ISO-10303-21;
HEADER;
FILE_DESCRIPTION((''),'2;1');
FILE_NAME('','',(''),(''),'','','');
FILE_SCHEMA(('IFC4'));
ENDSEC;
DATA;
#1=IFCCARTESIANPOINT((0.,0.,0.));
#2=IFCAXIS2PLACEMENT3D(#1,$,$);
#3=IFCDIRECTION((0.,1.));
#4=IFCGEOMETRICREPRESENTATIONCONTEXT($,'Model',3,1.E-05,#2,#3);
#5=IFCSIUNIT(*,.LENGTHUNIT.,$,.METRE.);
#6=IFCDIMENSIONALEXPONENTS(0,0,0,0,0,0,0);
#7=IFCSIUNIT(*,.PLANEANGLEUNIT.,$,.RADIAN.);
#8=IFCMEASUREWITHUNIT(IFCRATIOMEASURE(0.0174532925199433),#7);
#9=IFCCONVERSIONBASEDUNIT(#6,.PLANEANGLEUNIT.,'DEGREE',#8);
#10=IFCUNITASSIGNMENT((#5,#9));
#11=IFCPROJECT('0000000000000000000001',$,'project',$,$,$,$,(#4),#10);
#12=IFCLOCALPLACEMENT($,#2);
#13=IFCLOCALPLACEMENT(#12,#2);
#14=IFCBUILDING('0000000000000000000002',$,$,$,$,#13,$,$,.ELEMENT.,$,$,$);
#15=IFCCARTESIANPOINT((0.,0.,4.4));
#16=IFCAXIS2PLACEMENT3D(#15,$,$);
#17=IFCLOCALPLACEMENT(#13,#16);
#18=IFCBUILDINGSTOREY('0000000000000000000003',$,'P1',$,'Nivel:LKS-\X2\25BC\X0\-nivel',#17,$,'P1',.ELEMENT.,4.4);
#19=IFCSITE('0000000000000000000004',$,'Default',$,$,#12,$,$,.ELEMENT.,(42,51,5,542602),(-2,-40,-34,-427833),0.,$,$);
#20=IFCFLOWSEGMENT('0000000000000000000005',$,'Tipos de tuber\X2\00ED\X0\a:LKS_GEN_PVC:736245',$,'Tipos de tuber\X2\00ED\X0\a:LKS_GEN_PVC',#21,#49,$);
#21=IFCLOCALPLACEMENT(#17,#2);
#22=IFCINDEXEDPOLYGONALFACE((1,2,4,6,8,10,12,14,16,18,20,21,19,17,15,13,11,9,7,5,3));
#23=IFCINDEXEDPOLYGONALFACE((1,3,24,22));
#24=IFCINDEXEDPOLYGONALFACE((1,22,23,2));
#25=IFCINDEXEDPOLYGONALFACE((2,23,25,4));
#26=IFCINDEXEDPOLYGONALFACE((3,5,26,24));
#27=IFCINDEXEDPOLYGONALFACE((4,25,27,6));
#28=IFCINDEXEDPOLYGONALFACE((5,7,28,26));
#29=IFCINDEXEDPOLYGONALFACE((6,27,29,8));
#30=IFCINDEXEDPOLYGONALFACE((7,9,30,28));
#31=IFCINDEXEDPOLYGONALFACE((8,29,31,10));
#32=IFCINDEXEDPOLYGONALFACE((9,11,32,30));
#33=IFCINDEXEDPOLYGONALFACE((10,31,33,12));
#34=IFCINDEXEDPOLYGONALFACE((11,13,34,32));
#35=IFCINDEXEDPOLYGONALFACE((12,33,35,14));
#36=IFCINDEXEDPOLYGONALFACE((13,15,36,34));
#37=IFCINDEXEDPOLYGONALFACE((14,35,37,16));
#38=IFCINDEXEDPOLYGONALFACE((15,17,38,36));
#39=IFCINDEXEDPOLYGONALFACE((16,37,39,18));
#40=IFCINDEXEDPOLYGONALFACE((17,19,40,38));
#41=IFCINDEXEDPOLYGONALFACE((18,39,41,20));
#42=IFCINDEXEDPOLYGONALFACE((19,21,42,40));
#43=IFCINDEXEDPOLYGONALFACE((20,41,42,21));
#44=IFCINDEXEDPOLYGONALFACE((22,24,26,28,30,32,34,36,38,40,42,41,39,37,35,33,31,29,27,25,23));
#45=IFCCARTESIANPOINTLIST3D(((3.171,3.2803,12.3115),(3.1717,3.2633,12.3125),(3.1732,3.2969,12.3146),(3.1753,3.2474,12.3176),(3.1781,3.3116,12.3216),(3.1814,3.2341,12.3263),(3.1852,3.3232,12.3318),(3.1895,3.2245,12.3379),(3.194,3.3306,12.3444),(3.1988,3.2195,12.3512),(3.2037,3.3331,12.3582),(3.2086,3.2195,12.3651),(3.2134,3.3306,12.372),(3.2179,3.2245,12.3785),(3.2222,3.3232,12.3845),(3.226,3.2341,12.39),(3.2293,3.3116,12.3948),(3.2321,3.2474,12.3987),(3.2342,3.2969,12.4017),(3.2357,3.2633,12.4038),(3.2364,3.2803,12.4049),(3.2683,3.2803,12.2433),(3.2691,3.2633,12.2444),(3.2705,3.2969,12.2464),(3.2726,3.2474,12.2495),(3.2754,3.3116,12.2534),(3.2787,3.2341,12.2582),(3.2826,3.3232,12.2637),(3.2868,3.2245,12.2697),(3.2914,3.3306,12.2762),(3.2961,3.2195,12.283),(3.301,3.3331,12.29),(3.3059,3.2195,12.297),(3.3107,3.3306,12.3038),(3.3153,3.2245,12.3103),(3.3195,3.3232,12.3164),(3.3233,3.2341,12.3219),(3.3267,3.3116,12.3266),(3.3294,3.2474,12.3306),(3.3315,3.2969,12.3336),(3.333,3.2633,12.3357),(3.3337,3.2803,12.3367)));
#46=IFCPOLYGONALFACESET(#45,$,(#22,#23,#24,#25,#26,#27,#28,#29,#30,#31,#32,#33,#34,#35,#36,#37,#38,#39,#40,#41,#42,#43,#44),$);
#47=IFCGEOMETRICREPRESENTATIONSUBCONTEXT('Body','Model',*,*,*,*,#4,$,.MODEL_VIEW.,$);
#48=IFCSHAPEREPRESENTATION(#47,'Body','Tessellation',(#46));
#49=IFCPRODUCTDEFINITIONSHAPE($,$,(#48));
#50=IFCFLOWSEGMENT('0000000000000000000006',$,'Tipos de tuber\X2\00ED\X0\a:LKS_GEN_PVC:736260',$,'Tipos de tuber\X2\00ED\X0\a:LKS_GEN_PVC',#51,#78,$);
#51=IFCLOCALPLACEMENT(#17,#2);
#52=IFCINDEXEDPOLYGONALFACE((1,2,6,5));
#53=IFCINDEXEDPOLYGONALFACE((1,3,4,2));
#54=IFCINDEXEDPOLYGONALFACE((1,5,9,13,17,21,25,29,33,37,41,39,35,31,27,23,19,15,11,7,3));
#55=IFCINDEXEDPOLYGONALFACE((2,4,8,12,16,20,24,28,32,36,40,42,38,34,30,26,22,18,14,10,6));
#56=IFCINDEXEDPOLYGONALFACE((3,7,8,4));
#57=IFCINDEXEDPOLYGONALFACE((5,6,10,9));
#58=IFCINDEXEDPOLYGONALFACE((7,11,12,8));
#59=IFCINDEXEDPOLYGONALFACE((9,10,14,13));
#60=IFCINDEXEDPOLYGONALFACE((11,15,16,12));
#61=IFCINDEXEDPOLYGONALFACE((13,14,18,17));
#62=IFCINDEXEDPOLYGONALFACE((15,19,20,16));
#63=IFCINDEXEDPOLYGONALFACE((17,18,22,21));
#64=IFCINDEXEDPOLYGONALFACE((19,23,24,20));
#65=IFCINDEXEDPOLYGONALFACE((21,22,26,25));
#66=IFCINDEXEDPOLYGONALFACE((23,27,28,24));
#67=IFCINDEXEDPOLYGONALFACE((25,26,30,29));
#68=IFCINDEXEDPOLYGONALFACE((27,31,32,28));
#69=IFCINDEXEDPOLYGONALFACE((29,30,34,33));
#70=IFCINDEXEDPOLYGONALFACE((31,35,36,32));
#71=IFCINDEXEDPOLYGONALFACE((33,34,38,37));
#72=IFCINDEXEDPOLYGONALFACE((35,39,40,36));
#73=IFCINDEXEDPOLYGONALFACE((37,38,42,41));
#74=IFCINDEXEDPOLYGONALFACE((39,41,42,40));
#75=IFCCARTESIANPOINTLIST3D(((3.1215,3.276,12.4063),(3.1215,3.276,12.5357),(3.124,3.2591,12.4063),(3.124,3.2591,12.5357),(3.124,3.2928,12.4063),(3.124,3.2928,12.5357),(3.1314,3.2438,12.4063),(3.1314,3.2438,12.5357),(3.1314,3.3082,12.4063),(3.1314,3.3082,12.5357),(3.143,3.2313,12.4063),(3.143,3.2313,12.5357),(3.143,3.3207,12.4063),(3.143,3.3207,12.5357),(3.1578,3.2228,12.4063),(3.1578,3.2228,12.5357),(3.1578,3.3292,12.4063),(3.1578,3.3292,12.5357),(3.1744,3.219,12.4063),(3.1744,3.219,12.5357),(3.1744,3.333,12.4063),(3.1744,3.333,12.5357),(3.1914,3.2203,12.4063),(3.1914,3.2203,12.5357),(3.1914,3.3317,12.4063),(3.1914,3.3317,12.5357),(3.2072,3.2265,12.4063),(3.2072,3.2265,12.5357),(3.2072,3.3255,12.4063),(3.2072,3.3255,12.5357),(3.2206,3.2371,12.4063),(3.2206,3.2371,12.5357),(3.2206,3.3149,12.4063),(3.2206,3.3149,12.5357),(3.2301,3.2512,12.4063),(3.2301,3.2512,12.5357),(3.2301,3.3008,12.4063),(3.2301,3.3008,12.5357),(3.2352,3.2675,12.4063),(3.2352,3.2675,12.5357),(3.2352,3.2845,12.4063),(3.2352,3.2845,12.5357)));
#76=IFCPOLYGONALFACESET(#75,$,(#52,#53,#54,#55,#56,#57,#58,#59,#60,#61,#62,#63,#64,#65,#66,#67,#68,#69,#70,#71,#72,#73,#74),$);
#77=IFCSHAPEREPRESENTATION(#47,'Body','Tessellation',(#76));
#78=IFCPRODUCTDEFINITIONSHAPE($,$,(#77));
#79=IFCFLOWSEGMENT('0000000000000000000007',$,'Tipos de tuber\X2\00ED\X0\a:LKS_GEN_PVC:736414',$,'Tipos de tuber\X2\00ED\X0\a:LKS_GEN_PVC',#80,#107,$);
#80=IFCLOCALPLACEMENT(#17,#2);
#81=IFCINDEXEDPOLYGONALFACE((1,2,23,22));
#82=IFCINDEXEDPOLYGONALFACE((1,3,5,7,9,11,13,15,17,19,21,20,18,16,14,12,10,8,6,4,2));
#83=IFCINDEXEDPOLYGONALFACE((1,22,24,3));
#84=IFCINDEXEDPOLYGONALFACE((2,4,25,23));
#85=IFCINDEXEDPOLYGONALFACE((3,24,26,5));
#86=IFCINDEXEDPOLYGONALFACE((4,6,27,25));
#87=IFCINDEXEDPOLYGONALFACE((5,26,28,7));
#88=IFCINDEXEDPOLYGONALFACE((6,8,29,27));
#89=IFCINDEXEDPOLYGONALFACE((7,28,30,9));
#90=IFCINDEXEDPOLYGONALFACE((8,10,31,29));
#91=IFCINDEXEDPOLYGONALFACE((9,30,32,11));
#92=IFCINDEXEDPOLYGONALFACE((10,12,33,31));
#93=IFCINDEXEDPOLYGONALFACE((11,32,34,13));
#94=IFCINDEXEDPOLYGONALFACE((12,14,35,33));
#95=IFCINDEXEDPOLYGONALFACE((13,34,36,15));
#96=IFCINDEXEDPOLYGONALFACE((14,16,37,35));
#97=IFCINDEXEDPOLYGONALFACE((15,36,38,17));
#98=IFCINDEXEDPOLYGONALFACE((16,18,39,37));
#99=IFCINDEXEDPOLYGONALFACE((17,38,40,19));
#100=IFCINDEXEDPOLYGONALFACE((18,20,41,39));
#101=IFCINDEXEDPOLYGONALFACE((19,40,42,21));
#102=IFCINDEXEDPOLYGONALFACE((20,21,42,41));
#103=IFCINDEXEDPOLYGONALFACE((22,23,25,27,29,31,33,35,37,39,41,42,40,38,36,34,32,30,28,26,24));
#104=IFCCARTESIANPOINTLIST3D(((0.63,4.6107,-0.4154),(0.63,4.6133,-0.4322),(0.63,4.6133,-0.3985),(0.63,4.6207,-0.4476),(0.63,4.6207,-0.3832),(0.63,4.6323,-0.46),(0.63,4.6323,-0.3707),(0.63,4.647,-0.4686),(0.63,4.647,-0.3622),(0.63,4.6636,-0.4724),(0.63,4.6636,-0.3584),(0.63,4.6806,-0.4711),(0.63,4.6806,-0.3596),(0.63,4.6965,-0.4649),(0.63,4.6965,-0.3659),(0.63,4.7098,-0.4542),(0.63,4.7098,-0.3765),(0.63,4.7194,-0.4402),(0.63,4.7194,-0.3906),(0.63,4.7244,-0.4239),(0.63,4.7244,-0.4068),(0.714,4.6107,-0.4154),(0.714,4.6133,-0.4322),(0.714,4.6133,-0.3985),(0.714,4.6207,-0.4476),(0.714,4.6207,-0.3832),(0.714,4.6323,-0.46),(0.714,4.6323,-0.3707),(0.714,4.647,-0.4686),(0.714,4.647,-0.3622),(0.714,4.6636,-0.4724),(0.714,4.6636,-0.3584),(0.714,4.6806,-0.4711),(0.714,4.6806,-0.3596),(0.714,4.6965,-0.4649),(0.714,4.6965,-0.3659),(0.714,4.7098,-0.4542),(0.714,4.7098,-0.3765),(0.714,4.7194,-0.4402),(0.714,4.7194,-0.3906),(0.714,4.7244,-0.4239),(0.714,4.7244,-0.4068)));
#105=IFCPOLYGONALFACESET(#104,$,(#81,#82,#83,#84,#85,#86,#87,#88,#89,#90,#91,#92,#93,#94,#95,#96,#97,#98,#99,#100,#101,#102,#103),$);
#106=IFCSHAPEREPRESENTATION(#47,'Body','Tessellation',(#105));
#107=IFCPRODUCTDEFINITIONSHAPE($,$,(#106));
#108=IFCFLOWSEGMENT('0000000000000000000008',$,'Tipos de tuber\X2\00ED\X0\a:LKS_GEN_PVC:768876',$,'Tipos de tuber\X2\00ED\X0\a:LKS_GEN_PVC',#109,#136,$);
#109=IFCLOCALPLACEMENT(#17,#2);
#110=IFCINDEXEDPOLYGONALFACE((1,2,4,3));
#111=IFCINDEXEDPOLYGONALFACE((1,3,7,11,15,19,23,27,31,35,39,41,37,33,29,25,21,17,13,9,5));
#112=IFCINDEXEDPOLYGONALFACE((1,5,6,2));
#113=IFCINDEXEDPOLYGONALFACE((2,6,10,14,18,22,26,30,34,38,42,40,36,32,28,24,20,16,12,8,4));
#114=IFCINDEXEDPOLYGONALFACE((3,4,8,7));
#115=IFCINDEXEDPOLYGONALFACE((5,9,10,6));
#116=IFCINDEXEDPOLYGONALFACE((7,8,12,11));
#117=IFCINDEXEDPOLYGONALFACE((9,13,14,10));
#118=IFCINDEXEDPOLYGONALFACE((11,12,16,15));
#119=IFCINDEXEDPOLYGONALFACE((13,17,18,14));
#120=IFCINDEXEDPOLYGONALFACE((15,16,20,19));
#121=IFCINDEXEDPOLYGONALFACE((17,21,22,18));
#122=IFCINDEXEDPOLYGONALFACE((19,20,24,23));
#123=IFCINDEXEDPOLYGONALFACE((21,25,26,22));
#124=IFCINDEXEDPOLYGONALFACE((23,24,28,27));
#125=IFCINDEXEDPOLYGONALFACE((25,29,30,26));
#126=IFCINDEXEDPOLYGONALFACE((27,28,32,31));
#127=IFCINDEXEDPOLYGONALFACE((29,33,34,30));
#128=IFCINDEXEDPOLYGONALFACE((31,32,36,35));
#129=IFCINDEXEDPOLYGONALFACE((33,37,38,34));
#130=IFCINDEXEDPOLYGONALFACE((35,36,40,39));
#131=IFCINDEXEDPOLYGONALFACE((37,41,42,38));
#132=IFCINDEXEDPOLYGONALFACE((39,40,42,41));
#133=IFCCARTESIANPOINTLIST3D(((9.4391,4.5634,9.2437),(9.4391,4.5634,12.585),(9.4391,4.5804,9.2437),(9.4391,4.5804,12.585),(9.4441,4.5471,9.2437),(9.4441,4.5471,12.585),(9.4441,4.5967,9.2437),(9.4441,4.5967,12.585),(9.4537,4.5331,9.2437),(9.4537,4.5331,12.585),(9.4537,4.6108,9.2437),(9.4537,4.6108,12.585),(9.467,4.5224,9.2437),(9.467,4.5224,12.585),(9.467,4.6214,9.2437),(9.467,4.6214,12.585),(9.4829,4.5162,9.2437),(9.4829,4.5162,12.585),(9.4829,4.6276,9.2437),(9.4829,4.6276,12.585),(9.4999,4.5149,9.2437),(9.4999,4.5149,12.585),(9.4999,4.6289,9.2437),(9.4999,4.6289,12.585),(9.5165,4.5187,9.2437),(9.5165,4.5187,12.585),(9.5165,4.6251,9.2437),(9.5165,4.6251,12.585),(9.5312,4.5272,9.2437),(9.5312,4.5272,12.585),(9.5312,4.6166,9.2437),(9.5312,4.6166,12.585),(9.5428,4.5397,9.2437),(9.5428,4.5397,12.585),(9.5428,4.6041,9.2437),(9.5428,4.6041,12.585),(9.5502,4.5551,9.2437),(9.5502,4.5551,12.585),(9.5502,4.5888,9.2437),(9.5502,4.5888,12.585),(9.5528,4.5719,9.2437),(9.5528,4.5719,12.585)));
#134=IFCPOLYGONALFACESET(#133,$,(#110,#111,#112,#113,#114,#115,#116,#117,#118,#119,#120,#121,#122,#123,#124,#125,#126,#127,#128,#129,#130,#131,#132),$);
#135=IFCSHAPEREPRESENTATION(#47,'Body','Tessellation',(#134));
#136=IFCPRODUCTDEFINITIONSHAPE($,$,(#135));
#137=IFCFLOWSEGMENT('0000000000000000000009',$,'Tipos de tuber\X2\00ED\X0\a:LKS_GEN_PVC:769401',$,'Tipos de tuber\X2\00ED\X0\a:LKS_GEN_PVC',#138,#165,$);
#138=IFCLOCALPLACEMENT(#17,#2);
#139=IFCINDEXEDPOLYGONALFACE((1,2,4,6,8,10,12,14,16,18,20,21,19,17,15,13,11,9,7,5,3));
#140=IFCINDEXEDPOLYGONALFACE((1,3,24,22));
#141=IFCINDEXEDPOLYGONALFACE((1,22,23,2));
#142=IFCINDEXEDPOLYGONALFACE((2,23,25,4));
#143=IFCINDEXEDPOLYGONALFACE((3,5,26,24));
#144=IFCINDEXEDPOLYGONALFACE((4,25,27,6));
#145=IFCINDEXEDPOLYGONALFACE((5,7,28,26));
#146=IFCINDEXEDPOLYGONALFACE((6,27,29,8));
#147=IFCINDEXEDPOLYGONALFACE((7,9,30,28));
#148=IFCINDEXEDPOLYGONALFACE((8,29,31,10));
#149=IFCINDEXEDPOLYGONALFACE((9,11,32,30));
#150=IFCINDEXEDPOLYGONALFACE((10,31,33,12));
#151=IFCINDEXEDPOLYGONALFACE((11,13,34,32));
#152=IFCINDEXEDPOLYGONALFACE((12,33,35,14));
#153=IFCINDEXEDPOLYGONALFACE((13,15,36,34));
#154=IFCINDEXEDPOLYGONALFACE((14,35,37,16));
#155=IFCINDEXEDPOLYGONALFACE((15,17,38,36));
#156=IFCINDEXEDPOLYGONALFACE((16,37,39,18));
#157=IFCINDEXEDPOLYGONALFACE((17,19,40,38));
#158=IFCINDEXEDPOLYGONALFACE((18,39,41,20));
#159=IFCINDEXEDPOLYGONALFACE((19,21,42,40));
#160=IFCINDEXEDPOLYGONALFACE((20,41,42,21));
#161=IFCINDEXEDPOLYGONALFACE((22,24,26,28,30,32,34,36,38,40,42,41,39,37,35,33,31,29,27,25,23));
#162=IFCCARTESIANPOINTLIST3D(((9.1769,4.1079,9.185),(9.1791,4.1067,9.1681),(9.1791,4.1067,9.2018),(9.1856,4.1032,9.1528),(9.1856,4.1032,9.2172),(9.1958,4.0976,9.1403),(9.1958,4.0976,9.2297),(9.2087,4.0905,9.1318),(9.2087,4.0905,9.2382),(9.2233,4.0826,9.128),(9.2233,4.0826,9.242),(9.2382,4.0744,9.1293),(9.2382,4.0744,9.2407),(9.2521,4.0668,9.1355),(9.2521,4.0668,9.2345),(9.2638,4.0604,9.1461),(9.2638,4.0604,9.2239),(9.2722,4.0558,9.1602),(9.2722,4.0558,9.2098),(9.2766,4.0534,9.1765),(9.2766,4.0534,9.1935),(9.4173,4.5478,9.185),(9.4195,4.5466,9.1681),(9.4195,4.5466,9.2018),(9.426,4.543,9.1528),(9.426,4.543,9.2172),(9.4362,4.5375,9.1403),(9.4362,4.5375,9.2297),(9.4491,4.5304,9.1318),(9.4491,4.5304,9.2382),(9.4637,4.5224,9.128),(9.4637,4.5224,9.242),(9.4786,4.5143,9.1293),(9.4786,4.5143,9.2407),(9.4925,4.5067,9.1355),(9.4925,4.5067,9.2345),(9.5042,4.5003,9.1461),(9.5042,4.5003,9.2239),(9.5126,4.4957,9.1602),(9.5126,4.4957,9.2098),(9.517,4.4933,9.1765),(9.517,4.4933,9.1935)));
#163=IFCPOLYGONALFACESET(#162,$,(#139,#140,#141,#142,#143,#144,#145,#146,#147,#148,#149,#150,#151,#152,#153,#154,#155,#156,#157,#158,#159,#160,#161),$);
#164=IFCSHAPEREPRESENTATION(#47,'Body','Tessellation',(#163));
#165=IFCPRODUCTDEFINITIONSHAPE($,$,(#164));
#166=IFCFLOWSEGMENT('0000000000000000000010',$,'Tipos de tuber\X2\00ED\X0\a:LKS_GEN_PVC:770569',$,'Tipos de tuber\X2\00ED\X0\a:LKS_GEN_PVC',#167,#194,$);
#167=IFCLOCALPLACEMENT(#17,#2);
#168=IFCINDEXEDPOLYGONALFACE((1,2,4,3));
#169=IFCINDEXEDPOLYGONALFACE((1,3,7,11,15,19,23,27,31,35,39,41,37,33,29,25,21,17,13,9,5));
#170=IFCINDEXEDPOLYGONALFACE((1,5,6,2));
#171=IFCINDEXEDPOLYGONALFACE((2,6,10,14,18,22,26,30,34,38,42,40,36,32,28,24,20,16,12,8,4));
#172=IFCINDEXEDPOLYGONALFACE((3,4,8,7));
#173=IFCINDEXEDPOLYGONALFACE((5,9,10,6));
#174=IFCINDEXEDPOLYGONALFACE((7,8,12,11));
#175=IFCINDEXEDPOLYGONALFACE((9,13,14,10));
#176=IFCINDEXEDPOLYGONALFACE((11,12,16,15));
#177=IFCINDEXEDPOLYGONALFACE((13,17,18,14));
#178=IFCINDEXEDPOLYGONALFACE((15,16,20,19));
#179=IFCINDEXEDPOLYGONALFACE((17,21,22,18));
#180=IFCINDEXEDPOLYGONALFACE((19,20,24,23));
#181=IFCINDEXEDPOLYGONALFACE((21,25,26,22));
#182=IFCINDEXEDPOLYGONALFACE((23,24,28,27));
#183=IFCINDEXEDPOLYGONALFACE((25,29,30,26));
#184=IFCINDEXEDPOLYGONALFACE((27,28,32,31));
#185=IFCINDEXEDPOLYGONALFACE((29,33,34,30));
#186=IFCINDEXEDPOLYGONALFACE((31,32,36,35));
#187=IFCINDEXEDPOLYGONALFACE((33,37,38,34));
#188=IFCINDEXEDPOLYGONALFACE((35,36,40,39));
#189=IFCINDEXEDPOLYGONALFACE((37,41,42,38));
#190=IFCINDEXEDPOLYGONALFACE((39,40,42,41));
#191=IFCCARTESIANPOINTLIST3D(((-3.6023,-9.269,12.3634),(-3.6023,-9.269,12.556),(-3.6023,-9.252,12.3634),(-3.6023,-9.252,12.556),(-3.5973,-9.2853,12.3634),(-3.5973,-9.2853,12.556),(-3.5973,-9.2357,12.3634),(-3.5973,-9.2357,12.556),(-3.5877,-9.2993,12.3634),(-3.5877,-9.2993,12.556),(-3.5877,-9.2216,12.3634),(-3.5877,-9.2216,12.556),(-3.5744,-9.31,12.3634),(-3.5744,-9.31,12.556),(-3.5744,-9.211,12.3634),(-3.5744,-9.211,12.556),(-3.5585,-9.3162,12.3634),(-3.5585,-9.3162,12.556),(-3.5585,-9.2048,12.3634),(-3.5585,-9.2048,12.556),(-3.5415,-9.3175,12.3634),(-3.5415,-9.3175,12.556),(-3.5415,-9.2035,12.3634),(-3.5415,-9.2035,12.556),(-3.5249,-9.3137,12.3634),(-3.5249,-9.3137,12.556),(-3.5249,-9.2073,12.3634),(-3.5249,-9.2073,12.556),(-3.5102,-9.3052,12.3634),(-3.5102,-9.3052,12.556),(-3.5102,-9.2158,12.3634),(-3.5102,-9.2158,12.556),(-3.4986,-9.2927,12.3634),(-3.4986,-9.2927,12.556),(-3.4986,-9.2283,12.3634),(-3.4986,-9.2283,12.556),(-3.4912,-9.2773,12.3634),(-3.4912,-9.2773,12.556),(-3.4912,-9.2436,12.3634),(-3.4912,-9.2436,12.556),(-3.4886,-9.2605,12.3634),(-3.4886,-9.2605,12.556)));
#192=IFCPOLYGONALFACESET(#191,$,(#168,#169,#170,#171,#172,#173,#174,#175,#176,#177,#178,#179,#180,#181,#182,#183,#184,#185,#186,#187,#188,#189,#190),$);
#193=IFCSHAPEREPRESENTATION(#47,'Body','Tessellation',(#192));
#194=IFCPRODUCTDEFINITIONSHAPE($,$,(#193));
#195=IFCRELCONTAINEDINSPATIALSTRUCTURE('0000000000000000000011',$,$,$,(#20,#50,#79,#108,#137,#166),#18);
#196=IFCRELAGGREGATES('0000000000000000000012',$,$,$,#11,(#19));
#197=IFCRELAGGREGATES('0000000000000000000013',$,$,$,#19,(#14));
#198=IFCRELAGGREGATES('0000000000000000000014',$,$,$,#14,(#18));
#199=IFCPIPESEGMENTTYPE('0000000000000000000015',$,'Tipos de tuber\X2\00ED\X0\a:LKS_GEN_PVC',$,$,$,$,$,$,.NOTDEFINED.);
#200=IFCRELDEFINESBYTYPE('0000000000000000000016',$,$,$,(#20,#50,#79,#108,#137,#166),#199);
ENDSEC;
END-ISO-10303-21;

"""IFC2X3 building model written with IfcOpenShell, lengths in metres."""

from ifc_helpers import new_model, entity, si_unit, converted_unit, direction, frame, frame_2d, origin, origin_2d_with_axis, place, context, subcontext, project, spatial, circle, extrude, type_object, element, save


model = new_model("IFC2X3")

# Units and contexts
model_context = context("Model", 3, precision=1e-05, world=origin(), true_north=direction((0.0, 1.0)))
body_context = subcontext(model_context, "Body", "Model", "MODEL_VIEW")
ifc_project = project(units=[si_unit("LENGTHUNIT", "METRE"), converted_unit("PLANEANGLEUNIT", "DEGREE", entity("IfcRatioMeasure", 0.0174532925199433), si_unit("PLANEANGLEUNIT", "RADIAN"), dimensions=[0, 0, 0, 0, 0, 0, 0])], contexts=[model_context])

# Site, building, storey
site_placement = place(None, origin())
site = spatial("IfcSite", under=ifc_project, at=site_placement, Name="Default", CompositionType="ELEMENT", RefLatitude=(42, 51, 5, 542602), RefLongitude=(-2, -40, -34, -427833), RefElevation=0.0)
building_placement = place(site_placement, origin())
building = spatial("IfcBuilding", under=site, at=building_placement, CompositionType="ELEMENT")
storey_placement = place(building_placement, frame((0.0, 0.0, 4.4)))
storey = spatial("IfcBuildingStorey", under=building, at=storey_placement, Name="P1", ObjectType="Nivel:LKS-▼-nivel", LongName="P1", CompositionType="ELEMENT", Elevation=4.4)

# Flow segments
pipe_segment_type_1 = type_object("IfcPipeSegmentType", Name="Tipos de tubería:LKS_GEN_PVC", PredefinedType="NOTDEFINED")
flow_segment_1_placement = place(storey_placement, origin())
element("IfcFlowSegment", 1, at=flow_segment_1_placement, inside=storey, type_object=pipe_segment_type_1, Name="Tipos de tubería:LKS_GEN_PVC:736245", ObjectType="Tipos de tubería:LKS_GEN_PVC", context=body_context, shape_type="SweptSolid", body=[
    extrude(circle(Radius=0.0571, at=origin_2d_with_axis()), frame((3.2037, 3.276, 12.3582), z_axis=(0.819152, 0.0, -0.573576), x_axis=(0.0, 1.0, 0.0)), (0.0, 0.0, 1.0), 0.1188),
])
flow_segment_2_placement = place(storey_placement, origin())
element("IfcFlowSegment", 2, at=flow_segment_2_placement, inside=storey, type_object=pipe_segment_type_1, Name="Tipos de tubería:LKS_GEN_PVC:736260", ObjectType="Tipos de tubería:LKS_GEN_PVC", context=body_context, shape_type="SweptSolid", body=[
    extrude(circle(Radius=0.0571, at=origin_2d_with_axis()), frame((3.1787, 3.276, 12.4063), z_axis=(0.0, 0.0, 1.0), x_axis=(-1.0, 0.0, 0.0)), (0.0, 0.0, 1.0), 0.1294),
])
flow_segment_3_placement = place(storey_placement, origin())
element("IfcFlowSegment", 3, at=flow_segment_3_placement, inside=storey, type_object=pipe_segment_type_1, Name="Tipos de tubería:LKS_GEN_PVC:736414", ObjectType="Tipos de tubería:LKS_GEN_PVC", context=body_context, shape_type="SweptSolid", body=[
    extrude(circle(Radius=0.0571, at=frame_2d((0.0, 0.0), x_axis=(1.0, 0.0))), frame((0.63, 4.6679, -0.4154), z_axis=(1.0, 0.0, 0.0), x_axis=(0.0, -1.0, 0.0)), (0.0, 0.0, 1.0), 0.0839),
])
flow_segment_4_placement = place(storey_placement, origin())
element("IfcFlowSegment", 4, at=flow_segment_4_placement, inside=storey, type_object=pipe_segment_type_1, Name="Tipos de tubería:LKS_GEN_PVC:768876", ObjectType="Tipos de tubería:LKS_GEN_PVC", context=body_context, shape_type="SweptSolid", body=[
    extrude(circle(Radius=0.0571, at=origin_2d_with_axis()), frame((9.4956, 4.5719, 9.2437)), (0.0, 0.0, 1.0), 3.3413),
])
flow_segment_5_placement = place(storey_placement, origin())
element("IfcFlowSegment", 5, at=flow_segment_5_placement, inside=storey, type_object=pipe_segment_type_1, Name="Tipos de tubería:LKS_GEN_PVC:769401", ObjectType="Tipos de tubería:LKS_GEN_PVC", context=body_context, shape_type="SweptSolid", body=[
    extrude(circle(Radius=0.0571, at=frame_2d((0.0, 0.0), x_axis=(1.0, 0.0))), frame((9.2271, 4.0805, 9.185), z_axis=(0.479561, 0.877509, 0.0), x_axis=(-0.877509, 0.479561, 0.0)), (0.0, 0.0, 1.0), 0.5013),
])
flow_segment_6_placement = place(storey_placement, origin())
element("IfcFlowSegment", 6, at=flow_segment_6_placement, inside=storey, type_object=pipe_segment_type_1, Name="Tipos de tubería:LKS_GEN_PVC:770569", ObjectType="Tipos de tubería:LKS_GEN_PVC", context=body_context, shape_type="SweptSolid", body=[
    extrude(circle(Radius=0.0571, at=origin_2d_with_axis()), frame((-3.5458, -9.2605, 12.3634)), (0.0, 0.0, 1.0), 0.1926),
])

save(model, "model.ifc")
